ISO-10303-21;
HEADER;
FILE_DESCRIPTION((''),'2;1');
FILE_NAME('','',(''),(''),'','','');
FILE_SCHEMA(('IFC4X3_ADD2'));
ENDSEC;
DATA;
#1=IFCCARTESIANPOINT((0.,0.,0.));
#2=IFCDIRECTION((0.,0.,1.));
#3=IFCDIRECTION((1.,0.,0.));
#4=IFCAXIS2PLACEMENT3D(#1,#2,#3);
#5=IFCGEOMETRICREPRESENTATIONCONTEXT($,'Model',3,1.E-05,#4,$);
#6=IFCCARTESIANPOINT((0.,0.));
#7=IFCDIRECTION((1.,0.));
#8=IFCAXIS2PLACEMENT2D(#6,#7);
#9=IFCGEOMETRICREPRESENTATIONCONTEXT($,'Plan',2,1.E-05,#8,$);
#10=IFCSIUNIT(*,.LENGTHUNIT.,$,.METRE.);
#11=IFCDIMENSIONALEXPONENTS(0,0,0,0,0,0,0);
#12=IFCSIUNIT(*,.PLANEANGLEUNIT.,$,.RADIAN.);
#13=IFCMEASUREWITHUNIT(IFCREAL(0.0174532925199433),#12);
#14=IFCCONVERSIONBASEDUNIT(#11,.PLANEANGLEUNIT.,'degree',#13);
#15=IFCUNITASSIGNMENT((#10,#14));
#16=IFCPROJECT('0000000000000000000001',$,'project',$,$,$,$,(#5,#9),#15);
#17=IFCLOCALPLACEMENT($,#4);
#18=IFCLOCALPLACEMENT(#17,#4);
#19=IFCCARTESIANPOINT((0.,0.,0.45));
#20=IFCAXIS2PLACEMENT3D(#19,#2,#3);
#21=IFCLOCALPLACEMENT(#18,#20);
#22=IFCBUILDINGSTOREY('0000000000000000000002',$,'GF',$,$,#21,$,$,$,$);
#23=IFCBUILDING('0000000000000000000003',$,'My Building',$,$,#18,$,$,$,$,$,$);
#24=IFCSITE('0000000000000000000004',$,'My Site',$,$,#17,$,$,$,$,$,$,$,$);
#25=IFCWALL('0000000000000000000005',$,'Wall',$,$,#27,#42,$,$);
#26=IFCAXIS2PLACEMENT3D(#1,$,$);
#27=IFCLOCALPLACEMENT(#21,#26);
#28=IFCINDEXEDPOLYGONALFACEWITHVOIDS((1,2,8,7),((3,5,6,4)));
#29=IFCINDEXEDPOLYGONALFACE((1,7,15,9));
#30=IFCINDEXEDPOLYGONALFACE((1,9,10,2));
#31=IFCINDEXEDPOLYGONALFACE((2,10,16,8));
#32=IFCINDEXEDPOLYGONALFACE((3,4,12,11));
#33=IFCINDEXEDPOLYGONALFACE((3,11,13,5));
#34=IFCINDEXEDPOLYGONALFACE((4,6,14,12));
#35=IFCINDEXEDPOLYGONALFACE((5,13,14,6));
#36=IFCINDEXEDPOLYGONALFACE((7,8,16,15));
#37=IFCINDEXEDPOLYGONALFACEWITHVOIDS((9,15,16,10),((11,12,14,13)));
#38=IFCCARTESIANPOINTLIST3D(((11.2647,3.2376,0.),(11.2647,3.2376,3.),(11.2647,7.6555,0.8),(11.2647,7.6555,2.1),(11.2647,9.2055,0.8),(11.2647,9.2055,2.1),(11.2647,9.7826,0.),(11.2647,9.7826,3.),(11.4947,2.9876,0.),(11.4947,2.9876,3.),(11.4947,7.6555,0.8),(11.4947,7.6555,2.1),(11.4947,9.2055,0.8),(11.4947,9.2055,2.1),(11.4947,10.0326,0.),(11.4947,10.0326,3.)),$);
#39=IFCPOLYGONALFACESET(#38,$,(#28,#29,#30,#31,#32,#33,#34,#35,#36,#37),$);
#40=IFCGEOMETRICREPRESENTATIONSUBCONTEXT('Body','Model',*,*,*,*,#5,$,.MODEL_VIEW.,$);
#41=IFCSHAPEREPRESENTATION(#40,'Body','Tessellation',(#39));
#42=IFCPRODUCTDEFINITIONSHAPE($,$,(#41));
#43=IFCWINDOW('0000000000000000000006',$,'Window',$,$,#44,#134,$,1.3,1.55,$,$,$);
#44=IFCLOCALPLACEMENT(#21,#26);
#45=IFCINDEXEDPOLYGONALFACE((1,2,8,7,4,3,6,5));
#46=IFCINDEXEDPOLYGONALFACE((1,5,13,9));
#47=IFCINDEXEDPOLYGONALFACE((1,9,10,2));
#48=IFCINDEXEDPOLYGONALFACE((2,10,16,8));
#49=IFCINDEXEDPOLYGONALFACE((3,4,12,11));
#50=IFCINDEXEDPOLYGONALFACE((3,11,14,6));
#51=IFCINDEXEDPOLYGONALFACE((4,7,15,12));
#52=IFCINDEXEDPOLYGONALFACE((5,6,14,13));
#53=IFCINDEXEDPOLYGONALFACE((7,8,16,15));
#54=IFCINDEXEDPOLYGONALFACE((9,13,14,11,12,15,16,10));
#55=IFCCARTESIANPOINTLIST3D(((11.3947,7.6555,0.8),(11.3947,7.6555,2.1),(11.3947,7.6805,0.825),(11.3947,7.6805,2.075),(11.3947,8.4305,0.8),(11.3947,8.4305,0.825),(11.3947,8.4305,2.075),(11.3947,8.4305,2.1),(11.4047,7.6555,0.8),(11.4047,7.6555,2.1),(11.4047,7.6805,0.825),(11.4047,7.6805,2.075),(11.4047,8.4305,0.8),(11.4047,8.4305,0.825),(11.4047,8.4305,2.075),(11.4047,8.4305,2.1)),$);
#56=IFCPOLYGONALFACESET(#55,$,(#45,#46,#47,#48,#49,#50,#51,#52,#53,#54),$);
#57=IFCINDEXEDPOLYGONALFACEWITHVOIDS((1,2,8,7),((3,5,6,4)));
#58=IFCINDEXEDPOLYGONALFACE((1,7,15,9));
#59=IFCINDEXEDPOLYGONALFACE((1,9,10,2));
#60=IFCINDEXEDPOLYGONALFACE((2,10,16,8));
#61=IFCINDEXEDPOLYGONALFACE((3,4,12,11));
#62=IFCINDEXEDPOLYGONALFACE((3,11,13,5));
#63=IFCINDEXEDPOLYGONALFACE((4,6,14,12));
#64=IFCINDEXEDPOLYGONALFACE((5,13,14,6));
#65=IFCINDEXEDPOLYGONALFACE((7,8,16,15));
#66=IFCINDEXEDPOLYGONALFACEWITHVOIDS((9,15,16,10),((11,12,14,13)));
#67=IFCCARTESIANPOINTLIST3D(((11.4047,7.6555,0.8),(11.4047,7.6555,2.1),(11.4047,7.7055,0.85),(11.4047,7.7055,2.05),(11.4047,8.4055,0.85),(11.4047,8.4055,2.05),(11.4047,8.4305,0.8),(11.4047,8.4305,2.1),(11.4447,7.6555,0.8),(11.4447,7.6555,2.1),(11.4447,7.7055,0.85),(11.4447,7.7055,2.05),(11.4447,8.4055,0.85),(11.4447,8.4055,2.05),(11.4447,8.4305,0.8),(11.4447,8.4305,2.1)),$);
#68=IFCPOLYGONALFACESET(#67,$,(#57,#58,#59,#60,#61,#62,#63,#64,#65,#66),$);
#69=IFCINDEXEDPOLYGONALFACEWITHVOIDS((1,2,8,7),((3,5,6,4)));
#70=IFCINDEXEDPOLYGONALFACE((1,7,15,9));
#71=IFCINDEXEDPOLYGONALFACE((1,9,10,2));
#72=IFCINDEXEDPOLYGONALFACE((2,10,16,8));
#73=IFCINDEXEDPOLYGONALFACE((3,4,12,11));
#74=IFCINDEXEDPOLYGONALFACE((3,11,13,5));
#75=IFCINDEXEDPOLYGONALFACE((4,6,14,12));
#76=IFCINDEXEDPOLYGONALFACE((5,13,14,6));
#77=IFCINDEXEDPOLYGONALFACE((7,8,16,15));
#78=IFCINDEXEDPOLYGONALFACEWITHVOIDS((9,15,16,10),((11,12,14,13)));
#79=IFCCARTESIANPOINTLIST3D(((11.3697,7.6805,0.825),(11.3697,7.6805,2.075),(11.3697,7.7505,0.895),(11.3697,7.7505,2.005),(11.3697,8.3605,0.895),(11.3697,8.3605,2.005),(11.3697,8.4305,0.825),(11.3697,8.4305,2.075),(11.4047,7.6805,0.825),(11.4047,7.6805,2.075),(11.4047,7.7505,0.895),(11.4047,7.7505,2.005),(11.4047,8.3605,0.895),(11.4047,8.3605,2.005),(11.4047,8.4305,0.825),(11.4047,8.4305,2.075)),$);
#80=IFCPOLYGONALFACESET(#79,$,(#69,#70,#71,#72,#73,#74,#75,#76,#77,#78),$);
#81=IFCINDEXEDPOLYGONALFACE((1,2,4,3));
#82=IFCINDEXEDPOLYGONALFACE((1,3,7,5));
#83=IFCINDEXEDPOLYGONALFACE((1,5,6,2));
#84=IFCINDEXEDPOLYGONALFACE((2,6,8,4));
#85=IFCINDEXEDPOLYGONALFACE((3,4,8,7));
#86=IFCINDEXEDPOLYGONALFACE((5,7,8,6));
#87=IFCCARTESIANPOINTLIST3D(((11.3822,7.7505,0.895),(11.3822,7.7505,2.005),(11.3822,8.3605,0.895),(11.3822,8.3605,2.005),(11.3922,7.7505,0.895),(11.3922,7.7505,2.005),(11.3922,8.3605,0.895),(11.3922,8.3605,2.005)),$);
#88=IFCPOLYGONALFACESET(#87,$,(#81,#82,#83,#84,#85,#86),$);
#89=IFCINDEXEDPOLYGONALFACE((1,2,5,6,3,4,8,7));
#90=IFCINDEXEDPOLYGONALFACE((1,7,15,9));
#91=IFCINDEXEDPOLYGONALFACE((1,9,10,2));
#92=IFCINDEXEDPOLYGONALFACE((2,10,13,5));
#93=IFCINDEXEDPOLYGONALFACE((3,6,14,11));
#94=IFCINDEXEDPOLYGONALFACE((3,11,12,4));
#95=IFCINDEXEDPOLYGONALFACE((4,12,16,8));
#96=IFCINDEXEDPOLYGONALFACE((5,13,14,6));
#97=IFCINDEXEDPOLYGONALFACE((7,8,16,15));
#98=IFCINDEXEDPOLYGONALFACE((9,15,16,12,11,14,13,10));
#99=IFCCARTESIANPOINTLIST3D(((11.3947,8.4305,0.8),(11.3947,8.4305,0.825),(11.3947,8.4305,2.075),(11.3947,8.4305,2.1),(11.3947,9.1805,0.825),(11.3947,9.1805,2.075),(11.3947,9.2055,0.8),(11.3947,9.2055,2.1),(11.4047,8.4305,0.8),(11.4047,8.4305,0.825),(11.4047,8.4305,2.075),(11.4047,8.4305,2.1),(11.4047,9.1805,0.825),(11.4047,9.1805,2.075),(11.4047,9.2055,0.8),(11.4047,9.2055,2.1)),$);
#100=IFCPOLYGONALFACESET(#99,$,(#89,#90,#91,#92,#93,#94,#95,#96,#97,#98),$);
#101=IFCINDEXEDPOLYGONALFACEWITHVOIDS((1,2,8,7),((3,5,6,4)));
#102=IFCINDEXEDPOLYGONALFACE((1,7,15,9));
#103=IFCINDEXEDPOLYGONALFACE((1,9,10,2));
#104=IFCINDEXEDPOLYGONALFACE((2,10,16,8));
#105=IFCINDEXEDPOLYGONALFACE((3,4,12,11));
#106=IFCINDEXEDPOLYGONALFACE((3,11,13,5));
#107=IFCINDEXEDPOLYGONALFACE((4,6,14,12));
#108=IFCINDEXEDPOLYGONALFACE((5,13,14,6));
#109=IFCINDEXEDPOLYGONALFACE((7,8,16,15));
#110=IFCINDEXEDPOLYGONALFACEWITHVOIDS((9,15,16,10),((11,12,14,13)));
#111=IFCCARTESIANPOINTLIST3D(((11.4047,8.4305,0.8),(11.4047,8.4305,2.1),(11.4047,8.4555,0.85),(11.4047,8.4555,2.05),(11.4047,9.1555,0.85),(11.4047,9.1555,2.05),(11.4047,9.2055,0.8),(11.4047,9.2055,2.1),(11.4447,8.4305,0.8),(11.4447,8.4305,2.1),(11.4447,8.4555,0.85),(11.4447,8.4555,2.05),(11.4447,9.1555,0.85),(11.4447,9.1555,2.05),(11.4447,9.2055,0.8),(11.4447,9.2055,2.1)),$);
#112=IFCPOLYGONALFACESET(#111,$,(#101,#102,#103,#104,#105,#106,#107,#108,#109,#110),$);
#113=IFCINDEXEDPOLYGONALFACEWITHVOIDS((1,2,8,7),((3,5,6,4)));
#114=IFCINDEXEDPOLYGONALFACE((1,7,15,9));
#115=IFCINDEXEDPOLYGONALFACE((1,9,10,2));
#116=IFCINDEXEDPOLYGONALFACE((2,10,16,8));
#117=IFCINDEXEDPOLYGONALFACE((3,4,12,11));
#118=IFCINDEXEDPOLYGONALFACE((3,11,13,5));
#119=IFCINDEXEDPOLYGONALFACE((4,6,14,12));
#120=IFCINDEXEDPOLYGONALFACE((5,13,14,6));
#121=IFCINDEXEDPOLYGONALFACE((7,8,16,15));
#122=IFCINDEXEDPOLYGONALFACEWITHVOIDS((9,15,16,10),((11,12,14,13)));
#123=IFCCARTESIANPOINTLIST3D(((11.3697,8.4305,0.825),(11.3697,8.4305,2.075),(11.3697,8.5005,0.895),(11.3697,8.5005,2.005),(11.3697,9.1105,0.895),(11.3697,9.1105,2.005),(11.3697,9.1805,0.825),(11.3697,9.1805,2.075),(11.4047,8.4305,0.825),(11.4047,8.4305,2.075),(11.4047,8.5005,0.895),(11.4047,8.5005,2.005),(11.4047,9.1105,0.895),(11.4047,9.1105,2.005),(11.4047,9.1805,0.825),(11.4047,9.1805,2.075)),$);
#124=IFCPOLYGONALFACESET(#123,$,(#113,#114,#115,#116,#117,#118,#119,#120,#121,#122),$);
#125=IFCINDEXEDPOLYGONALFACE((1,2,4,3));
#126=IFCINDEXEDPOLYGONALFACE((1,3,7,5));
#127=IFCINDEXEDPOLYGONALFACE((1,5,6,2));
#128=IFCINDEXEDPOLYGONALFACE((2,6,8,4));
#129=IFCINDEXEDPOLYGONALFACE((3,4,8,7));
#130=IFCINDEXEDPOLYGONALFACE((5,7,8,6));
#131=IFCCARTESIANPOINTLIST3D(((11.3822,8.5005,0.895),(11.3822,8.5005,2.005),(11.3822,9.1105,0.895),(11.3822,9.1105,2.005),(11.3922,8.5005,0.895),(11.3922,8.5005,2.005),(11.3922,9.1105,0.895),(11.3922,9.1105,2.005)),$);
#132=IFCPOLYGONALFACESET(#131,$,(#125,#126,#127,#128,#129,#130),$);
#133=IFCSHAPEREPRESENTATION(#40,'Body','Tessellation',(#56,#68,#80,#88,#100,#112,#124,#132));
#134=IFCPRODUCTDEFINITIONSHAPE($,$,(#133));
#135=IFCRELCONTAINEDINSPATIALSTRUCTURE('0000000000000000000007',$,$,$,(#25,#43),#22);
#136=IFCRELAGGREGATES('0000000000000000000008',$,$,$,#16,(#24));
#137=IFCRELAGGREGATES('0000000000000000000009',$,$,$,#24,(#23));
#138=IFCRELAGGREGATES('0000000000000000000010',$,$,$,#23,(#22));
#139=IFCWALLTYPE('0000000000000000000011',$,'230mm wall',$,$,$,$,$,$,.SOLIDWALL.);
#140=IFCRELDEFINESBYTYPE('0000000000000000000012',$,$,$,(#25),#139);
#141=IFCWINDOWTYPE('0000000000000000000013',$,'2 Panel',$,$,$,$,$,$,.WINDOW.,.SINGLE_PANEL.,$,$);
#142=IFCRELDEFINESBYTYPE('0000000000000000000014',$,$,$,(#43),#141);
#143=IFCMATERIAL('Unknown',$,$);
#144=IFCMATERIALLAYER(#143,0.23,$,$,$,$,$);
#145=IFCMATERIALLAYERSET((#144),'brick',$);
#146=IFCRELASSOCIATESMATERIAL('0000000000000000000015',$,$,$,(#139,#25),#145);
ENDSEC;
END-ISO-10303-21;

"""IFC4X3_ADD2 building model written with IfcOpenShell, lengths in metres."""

from ifc_helpers import new_model, entity, si_unit, converted_unit, frame, origin_with_axes, origin_2d_with_axis, place, context, subcontext, project, spatial, line, indexed_curve, outline, extrude, shape, source, transform, mapped, material, layer, layer_set, layer_usage, type_object, type_shapes, element, fill, save


model = new_model("IFC4X3_ADD2")

# Units and contexts
model_context = context("Model", 3, precision=1e-05, world=origin_with_axes())
plan_context = context("Plan", 2, precision=1e-05, world=origin_2d_with_axis())
body_context_1 = subcontext(model_context, "Body", "Model", "MODEL_VIEW")
body_context_2 = subcontext(plan_context, "Body", "Plan", "PLAN_VIEW")
ifc_project = project(units=[si_unit("LENGTHUNIT", "METRE"), converted_unit("PLANEANGLEUNIT", "degree", entity("IfcReal", 0.0174532925199433), si_unit("PLANEANGLEUNIT", "RADIAN"), dimensions=[0, 0, 0, 0, 0, 0, 0])], contexts=[model_context, plan_context])

# Site, building, storey
site_placement = place(None, origin_with_axes())
site = spatial("IfcSite", under=ifc_project, at=site_placement, Name="My Site")
building_placement = place(site_placement, origin_with_axes())
building = spatial("IfcBuilding", under=site, at=building_placement, Name="My Building")
storey_placement = place(building_placement, frame((0.0, 0.0, 0.45), z_axis=(0.0, 0.0, 1.0), x_axis=(1.0, 0.0, 0.0)))
storey = spatial("IfcBuildingStorey", under=building, at=storey_placement, Name="GF")

# Wall, opening, window
ifc_material_1 = material(Name="Unknown")
ifc_layer = layer(ifc_material_1, 0.23)
ifc_layer_set = layer_set([ifc_layer], Name="brick")
ifc_layer_usage = layer_usage(ifc_layer_set, "AXIS2", "POSITIVE", 0.0)
wall_type = type_object("IfcWallType", Name="230mm wall", PredefinedType="SOLIDWALL", material=ifc_layer_set)
wall_placement = place(storey_placement, frame((11.4947, 2.9876, 0.0), z_axis=(0.0, 0.0, 1.0), x_axis=(0.0, 1.0, 0.0)))
wall = element("IfcWall", 1, at=wall_placement, inside=storey, type_object=wall_type, material=ifc_layer_usage, Name="Wall", context=body_context_1, shape_type="SweptSolid", body=[
    extrude(outline(indexed_curve([(0.0, 0.0), (0.25, 0.23), (6.795, 0.23), (7.045, 0.0)], segments=[line(1, 2, 3, 4, 1)])), origin_with_axes(), (0.0, 0.0, 1.0), 3.0),
])
shared_shape_1 = source(origin_with_axes(), body_context_1, "Body", "SweptSolid", [
    extrude(outline(indexed_curve([(0.0, 0.0), (1.55, 0.0), (1.55, 1.3), (0.0, 1.3)], segments=[line(1, 2, 3, 4, 1)])), frame((0.0, -0.6, 0.0), z_axis=(0.0, -1.0, 0.0), x_axis=(1.0, 0.0, 0.0)), (0.0, 0.0, -1.0), 1.2),
])
opening_placement = place(wall_placement, frame((4.668, 0.0, 0.8), z_axis=(0.0, 0.0, 1.0), x_axis=(1.0, 0.0, 0.0)))
opening = element("IfcOpeningElement", 2, at=opening_placement, cuts=wall, PredefinedType="OPENING", context=body_context_1, shape_type="MappedRepresentation", body=[
    mapped(shared_shape_1, transform((0.0, 0.0, 0.0), x_axis=(1.0, 0.0, 0.0), y_axis=(0.0, 1.0, 0.0), z_axis=(0.0, 0.0, 1.0), scale=1.0)),
])
window_type = type_object("IfcWindowType", Name="2 Panel", PartitioningType="SINGLE_PANEL", PredefinedType="WINDOW")
shared_shape_2 = source(origin_with_axes(), body_context_1, "Body", "SweptSolid", [
    extrude(outline(indexed_curve([(0.775, 0.0), (0.0, 0.0), (0.0, 1.3), (0.775, 1.3), (0.775, 1.275), (0.025, 1.275), (0.025, 0.025), (0.775, 0.025)], segments=[line(1, 2, 3, 4, 5, 6, 7, 8, 1)])), frame((0.0, 0.09, 0.0), z_axis=(0.0, -1.0, 0.0), x_axis=(1.0, 0.0, 0.0)), (0.0, 0.0, -1.0), 0.01),
    extrude(outline(indexed_curve([(0.0, 0.0), (0.775, 0.0), (0.775, 1.3), (0.0, 1.3)], segments=[line(1, 2, 3, 4, 1)]), holes=[indexed_curve([(0.05, 0.05), (0.75, 0.05), (0.75, 1.25), (0.05, 1.25)], segments=[line(1, 2, 3, 4, 1)])]), frame((0.0, 0.05, 0.0), z_axis=(0.0, -1.0, 0.0), x_axis=(1.0, 0.0, 0.0)), (0.0, 0.0, -1.0), 0.04),
    extrude(outline(indexed_curve([(0.0, 0.0), (0.75, 0.0), (0.75, 1.25), (0.0, 1.25)], segments=[line(1, 2, 3, 4, 1)]), holes=[indexed_curve([(0.07, 0.07), (0.68, 0.07), (0.68, 1.18), (0.07, 1.18)], segments=[line(1, 2, 3, 4, 1)])]), frame((0.025, 0.09, 0.025), z_axis=(0.0, -1.0, 0.0), x_axis=(1.0, 0.0, 0.0)), (0.0, 0.0, -1.0), 0.035),
    extrude(outline(indexed_curve([(0.07, 0.07), (0.68, 0.07), (0.68, 1.18), (0.07, 1.18)], segments=[line(1, 2, 3, 4, 1)])), frame((0.025, 0.1025, 0.025), z_axis=(0.0, -1.0, 0.0), x_axis=(1.0, 0.0, 0.0)), (0.0, 0.0, -1.0), 0.01),
    extrude(outline(indexed_curve([(0.0, 1.3), (0.775, 1.3), (0.775, 0.0), (0.0, 0.0), (0.0, 0.025), (0.75, 0.025), (0.75, 1.275), (0.0, 1.275)], segments=[line(1, 2, 3, 4, 5, 6, 7, 8, 1)])), frame((0.775, 0.09, 0.0), z_axis=(0.0, -1.0, 0.0), x_axis=(1.0, 0.0, 0.0)), (0.0, 0.0, -1.0), 0.01),
    extrude(outline(indexed_curve([(0.0, 0.0), (0.775, 0.0), (0.775, 1.3), (0.0, 1.3)], segments=[line(1, 2, 3, 4, 1)]), holes=[indexed_curve([(0.025, 0.05), (0.725, 0.05), (0.725, 1.25), (0.025, 1.25)], segments=[line(1, 2, 3, 4, 1)])]), frame((0.775, 0.05, 0.0), z_axis=(0.0, -1.0, 0.0), x_axis=(1.0, 0.0, 0.0)), (0.0, 0.0, -1.0), 0.04),
    extrude(outline(indexed_curve([(0.0, 0.0), (0.75, 0.0), (0.75, 1.25), (0.0, 1.25)], segments=[line(1, 2, 3, 4, 1)]), holes=[indexed_curve([(0.07, 0.07), (0.68, 0.07), (0.68, 1.18), (0.07, 1.18)], segments=[line(1, 2, 3, 4, 1)])]), frame((0.775, 0.09, 0.025), z_axis=(0.0, -1.0, 0.0), x_axis=(1.0, 0.0, 0.0)), (0.0, 0.0, -1.0), 0.035),
    extrude(outline(indexed_curve([(0.07, 0.07), (0.68, 0.07), (0.68, 1.18), (0.07, 1.18)], segments=[line(1, 2, 3, 4, 1)])), frame((0.775, 0.1025, 0.025), z_axis=(0.0, -1.0, 0.0), x_axis=(1.0, 0.0, 0.0)), (0.0, 0.0, -1.0), 0.01),
])
shared_shape_3 = source(origin_with_axes(), body_context_2, "Body", "Curve2D", [
    entity("IfcIndexedPolyCurve", entity("IfcCartesianPointList2D", [[0.05, 0.05], [0.75, 0.05]])),
    entity("IfcIndexedPolyCurve", entity("IfcCartesianPointList2D", [[0.0, 0.1], [0.025, 0.1], [0.025, 0.09], [0.05, 0.09], [0.05, 0.05], [0.0, 0.05]]), [entity("IfcLineIndex", [1, 2, 3, 4, 5, 6, 1])]),
    entity("IfcIndexedPolyCurve", entity("IfcCartesianPointList2D", [[0.775, 0.1], [0.775, 0.1], [0.775, 0.09], [0.75, 0.09], [0.75, 0.05], [0.775, 0.05]])),
    entity("IfcIndexedPolyCurve", entity("IfcCartesianPointList2D", [[0.025, 0.09], [0.095, 0.09], [0.095, 0.125], [0.025, 0.125]]), [entity("IfcLineIndex", [1, 2, 3, 4, 1])]),
    entity("IfcIndexedPolyCurve", entity("IfcCartesianPointList2D", [[0.775, 0.09], [0.705, 0.09], [0.705, 0.125], [0.775, 0.125]]), [entity("IfcLineIndex", [1, 2, 3, 4, 1])]),
    entity("IfcIndexedPolyCurve", entity("IfcCartesianPointList2D", [[0.095, 0.09], [0.705, 0.09]])),
    entity("IfcIndexedPolyCurve", entity("IfcCartesianPointList2D", [[0.095, 0.125], [0.705, 0.125]])),
    entity("IfcIndexedPolyCurve", entity("IfcCartesianPointList2D", [[0.095, 0.1075], [0.705, 0.1075]])),
    entity("IfcIndexedPolyCurve", entity("IfcCartesianPointList2D", [[0.8, 0.05], [1.5, 0.05]])),
    entity("IfcIndexedPolyCurve", entity("IfcCartesianPointList2D", [[0.775, 0.1], [0.775, 0.1], [0.775, 0.09], [0.8, 0.09], [0.8, 0.05], [0.775, 0.05]])),
    entity("IfcIndexedPolyCurve", entity("IfcCartesianPointList2D", [[1.55, 0.1], [1.525, 0.1], [1.525, 0.09], [1.5, 0.09], [1.5, 0.05], [1.55, 0.05]]), [entity("IfcLineIndex", [1, 2, 3, 4, 5, 6, 1])]),
    entity("IfcIndexedPolyCurve", entity("IfcCartesianPointList2D", [[0.775, 0.09], [0.845, 0.09], [0.845, 0.125], [0.775, 0.125]]), [entity("IfcLineIndex", [1, 2, 3, 4, 1])]),
    entity("IfcIndexedPolyCurve", entity("IfcCartesianPointList2D", [[1.525, 0.09], [1.455, 0.09], [1.455, 0.125], [1.525, 0.125]]), [entity("IfcLineIndex", [1, 2, 3, 4, 1])]),
    entity("IfcIndexedPolyCurve", entity("IfcCartesianPointList2D", [[0.845, 0.09], [1.455, 0.09]])),
    entity("IfcIndexedPolyCurve", entity("IfcCartesianPointList2D", [[0.845, 0.125], [1.455, 0.125]])),
    entity("IfcIndexedPolyCurve", entity("IfcCartesianPointList2D", [[0.845, 0.1075], [1.455, 0.1075]])),
])
type_shapes(window_type, [shared_shape_2, shared_shape_3])
window_1_placement = place(opening_placement, origin_with_axes())
window_1 = element("IfcWindow", 3, at=window_1_placement, inside=storey, type_object=window_type, Name="Window", OverallHeight=1.3, OverallWidth=1.55, shapes=[
    shape(body_context_1, "Body", "MappedRepresentation", [mapped(shared_shape_2, transform((0.0, 0.0, 0.0), x_axis=(1.0, 0.0, 0.0), y_axis=(0.0, 1.0, 0.0), z_axis=(0.0, 0.0, 1.0), scale=1.0))]),
    shape(body_context_2, "Body", "MappedRepresentation", [mapped(shared_shape_3, transform((0.0, 0.0, 0.0), x_axis=(1.0, 0.0, 0.0), y_axis=(0.0, 1.0, 0.0), z_axis=(0.0, 0.0, 1.0), scale=1.0))]),
])
fill(opening, window_1)

save(model, "model.ifc")
